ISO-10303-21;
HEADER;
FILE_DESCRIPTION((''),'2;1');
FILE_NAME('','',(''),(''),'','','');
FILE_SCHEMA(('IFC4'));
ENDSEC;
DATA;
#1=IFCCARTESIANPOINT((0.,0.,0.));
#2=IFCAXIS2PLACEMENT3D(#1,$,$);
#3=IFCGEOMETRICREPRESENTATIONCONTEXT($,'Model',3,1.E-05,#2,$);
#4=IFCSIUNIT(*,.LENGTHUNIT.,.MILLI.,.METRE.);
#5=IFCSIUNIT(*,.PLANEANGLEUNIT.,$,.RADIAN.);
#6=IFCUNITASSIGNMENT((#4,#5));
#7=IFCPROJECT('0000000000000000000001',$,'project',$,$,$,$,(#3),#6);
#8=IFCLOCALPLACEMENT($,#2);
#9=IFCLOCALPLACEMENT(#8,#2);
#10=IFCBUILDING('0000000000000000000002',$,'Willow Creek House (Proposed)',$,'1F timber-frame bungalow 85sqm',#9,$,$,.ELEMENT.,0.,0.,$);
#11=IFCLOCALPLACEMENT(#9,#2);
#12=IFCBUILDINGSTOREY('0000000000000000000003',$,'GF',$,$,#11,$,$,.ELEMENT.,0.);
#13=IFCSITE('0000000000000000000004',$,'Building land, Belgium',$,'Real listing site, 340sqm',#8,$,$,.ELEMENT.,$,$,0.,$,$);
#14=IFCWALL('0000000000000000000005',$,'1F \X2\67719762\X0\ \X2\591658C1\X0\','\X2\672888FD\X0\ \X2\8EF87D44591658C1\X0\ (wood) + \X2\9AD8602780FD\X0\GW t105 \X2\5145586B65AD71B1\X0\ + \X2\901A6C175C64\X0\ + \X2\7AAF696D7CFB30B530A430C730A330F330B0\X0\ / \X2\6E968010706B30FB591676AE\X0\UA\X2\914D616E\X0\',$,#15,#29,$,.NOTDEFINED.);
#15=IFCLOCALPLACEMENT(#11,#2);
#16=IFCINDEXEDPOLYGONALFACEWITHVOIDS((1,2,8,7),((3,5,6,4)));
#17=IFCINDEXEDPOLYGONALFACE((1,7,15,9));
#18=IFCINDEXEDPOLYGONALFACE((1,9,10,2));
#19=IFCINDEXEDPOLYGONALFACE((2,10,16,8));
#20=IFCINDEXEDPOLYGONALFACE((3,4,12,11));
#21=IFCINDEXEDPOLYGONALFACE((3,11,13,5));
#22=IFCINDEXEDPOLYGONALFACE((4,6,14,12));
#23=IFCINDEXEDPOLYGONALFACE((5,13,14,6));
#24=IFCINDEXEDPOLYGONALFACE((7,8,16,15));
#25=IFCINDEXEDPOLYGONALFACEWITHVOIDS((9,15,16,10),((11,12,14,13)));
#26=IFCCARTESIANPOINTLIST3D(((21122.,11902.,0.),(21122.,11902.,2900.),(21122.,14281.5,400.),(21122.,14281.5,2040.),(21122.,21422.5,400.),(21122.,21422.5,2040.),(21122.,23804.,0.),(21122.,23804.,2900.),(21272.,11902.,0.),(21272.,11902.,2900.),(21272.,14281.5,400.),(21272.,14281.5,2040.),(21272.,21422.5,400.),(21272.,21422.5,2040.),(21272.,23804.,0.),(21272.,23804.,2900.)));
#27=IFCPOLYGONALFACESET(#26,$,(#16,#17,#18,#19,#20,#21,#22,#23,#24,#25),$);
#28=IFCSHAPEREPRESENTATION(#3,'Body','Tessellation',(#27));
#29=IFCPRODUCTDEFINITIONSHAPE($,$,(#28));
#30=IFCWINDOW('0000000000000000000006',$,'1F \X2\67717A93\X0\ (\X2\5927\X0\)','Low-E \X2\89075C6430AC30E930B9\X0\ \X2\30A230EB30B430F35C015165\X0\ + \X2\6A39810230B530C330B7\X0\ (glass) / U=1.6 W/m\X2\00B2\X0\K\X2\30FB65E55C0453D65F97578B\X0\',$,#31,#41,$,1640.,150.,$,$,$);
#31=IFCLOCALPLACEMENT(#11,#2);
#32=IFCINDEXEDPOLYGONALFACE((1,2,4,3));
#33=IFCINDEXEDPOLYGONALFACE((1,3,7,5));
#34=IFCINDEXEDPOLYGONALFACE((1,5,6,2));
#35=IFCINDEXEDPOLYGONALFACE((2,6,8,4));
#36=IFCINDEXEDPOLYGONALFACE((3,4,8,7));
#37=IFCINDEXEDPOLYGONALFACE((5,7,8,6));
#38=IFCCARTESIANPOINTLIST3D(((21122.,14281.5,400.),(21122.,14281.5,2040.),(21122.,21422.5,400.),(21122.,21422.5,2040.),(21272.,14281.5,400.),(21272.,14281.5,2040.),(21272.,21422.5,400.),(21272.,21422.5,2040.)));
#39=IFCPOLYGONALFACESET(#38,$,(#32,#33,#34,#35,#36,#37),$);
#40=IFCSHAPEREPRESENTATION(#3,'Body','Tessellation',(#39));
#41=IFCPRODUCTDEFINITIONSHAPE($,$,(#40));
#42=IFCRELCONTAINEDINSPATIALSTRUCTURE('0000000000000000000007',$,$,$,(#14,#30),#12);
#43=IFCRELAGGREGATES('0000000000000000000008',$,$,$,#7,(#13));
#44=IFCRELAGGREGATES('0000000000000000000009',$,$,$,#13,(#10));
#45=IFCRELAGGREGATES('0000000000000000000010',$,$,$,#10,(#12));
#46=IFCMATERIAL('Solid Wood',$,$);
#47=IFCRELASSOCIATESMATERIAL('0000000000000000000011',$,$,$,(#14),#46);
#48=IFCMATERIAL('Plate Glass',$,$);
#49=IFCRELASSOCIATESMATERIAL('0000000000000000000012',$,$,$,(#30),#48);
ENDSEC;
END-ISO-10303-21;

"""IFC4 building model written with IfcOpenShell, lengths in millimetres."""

from ifc_helpers import new_model, si_unit, frame, frame_2d, origin, place, context, project, spatial, rectangle, extrude, material, element, fill, save


model = new_model("IFC4")

# Units and contexts
model_context = context("Model", 3, precision=1e-05, world=origin())
ifc_project = project(units=[si_unit("LENGTHUNIT", "METRE", prefix="MILLI"), si_unit("PLANEANGLEUNIT", "RADIAN")], contexts=[model_context])

# Site, building, storey
site_placement = place(None, origin())
site = spatial("IfcSite", under=ifc_project, at=site_placement, Name="Building land, Belgium", ObjectType="Real listing site, 340sqm", CompositionType="ELEMENT", RefElevation=0.0)
building_placement = place(site_placement, origin())
building = spatial("IfcBuilding", under=site, at=building_placement, Name="Willow Creek House (Proposed)", ObjectType="1F timber-frame bungalow 85sqm", CompositionType="ELEMENT", ElevationOfRefHeight=0.0, ElevationOfTerrain=0.0)
storey_placement = place(building_placement, origin())
storey = spatial("IfcBuildingStorey", under=building, at=storey_placement, Name="GF", CompositionType="ELEMENT", Elevation=0.0)

# Shared definitions
ifc_material_1 = material(Name="Solid Wood")

# Shared definitions
ifc_material_2 = material(Name="Plate Glass")

# Wall, opening, window
wall_1_placement = place(storey_placement, frame((10561.0, 5951.0, 0.0)))
wall_1 = element("IfcWall", 1, at=wall_1_placement, inside=storey, material=ifc_material_1, Name="1F 東面 外壁", Description="木製 軸組外壁 (wood) + 高性能GW t105 充填断熱 + 通気層 + 窯業系サイディング / 準耐火・外皮UA配慮", PredefinedType="NOTDEFINED", context=model_context, shape_type="SweptSolid", body=[
    extrude(rectangle(XDim=150.0, YDim=11902.0, at=frame_2d((75.0, 5951.0))), frame((10561.0, 5951.0, 0.0)), (0.0, 0.0, 1.0), 2900.0),
])
opening_1_placement = place(storey_placement, frame((10561.0, 7141.0, 200.0)))
opening_1 = element("IfcOpeningElement", 2, at=opening_1_placement, cuts=wall_1, PredefinedType="NOTDEFINED", context=model_context, shape_type="SweptSolid", body=[
    extrude(rectangle(XDim=150.0, YDim=7141.0, at=frame_2d((75.0, 3570.0))), frame((10561.0, 7141.0, 200.0)), (0.0, 0.0, 1.0), 1640.0),
])
window_1_placement = place(storey_placement, frame((10561.0, 7141.0, 200.0)))
window_1 = element("IfcWindow", 3, at=window_1_placement, inside=storey, material=ifc_material_2, Name="1F 東窓 (大)", Description="Low-E 複層ガラス アルゴン封入 + 樹脂サッシ (glass) / U=1.6 W/m²K・日射取得型", OverallHeight=1640.0, OverallWidth=150.0, context=model_context, shape_type="SweptSolid", body=[
    extrude(rectangle(XDim=150.0, YDim=7141.0, at=frame_2d((75.0, 3570.0))), frame((10561.0, 7141.0, 200.0)), (0.0, 0.0, 1.0), 1640.0),
])
fill(opening_1, window_1)

save(model, "model.ifc")
